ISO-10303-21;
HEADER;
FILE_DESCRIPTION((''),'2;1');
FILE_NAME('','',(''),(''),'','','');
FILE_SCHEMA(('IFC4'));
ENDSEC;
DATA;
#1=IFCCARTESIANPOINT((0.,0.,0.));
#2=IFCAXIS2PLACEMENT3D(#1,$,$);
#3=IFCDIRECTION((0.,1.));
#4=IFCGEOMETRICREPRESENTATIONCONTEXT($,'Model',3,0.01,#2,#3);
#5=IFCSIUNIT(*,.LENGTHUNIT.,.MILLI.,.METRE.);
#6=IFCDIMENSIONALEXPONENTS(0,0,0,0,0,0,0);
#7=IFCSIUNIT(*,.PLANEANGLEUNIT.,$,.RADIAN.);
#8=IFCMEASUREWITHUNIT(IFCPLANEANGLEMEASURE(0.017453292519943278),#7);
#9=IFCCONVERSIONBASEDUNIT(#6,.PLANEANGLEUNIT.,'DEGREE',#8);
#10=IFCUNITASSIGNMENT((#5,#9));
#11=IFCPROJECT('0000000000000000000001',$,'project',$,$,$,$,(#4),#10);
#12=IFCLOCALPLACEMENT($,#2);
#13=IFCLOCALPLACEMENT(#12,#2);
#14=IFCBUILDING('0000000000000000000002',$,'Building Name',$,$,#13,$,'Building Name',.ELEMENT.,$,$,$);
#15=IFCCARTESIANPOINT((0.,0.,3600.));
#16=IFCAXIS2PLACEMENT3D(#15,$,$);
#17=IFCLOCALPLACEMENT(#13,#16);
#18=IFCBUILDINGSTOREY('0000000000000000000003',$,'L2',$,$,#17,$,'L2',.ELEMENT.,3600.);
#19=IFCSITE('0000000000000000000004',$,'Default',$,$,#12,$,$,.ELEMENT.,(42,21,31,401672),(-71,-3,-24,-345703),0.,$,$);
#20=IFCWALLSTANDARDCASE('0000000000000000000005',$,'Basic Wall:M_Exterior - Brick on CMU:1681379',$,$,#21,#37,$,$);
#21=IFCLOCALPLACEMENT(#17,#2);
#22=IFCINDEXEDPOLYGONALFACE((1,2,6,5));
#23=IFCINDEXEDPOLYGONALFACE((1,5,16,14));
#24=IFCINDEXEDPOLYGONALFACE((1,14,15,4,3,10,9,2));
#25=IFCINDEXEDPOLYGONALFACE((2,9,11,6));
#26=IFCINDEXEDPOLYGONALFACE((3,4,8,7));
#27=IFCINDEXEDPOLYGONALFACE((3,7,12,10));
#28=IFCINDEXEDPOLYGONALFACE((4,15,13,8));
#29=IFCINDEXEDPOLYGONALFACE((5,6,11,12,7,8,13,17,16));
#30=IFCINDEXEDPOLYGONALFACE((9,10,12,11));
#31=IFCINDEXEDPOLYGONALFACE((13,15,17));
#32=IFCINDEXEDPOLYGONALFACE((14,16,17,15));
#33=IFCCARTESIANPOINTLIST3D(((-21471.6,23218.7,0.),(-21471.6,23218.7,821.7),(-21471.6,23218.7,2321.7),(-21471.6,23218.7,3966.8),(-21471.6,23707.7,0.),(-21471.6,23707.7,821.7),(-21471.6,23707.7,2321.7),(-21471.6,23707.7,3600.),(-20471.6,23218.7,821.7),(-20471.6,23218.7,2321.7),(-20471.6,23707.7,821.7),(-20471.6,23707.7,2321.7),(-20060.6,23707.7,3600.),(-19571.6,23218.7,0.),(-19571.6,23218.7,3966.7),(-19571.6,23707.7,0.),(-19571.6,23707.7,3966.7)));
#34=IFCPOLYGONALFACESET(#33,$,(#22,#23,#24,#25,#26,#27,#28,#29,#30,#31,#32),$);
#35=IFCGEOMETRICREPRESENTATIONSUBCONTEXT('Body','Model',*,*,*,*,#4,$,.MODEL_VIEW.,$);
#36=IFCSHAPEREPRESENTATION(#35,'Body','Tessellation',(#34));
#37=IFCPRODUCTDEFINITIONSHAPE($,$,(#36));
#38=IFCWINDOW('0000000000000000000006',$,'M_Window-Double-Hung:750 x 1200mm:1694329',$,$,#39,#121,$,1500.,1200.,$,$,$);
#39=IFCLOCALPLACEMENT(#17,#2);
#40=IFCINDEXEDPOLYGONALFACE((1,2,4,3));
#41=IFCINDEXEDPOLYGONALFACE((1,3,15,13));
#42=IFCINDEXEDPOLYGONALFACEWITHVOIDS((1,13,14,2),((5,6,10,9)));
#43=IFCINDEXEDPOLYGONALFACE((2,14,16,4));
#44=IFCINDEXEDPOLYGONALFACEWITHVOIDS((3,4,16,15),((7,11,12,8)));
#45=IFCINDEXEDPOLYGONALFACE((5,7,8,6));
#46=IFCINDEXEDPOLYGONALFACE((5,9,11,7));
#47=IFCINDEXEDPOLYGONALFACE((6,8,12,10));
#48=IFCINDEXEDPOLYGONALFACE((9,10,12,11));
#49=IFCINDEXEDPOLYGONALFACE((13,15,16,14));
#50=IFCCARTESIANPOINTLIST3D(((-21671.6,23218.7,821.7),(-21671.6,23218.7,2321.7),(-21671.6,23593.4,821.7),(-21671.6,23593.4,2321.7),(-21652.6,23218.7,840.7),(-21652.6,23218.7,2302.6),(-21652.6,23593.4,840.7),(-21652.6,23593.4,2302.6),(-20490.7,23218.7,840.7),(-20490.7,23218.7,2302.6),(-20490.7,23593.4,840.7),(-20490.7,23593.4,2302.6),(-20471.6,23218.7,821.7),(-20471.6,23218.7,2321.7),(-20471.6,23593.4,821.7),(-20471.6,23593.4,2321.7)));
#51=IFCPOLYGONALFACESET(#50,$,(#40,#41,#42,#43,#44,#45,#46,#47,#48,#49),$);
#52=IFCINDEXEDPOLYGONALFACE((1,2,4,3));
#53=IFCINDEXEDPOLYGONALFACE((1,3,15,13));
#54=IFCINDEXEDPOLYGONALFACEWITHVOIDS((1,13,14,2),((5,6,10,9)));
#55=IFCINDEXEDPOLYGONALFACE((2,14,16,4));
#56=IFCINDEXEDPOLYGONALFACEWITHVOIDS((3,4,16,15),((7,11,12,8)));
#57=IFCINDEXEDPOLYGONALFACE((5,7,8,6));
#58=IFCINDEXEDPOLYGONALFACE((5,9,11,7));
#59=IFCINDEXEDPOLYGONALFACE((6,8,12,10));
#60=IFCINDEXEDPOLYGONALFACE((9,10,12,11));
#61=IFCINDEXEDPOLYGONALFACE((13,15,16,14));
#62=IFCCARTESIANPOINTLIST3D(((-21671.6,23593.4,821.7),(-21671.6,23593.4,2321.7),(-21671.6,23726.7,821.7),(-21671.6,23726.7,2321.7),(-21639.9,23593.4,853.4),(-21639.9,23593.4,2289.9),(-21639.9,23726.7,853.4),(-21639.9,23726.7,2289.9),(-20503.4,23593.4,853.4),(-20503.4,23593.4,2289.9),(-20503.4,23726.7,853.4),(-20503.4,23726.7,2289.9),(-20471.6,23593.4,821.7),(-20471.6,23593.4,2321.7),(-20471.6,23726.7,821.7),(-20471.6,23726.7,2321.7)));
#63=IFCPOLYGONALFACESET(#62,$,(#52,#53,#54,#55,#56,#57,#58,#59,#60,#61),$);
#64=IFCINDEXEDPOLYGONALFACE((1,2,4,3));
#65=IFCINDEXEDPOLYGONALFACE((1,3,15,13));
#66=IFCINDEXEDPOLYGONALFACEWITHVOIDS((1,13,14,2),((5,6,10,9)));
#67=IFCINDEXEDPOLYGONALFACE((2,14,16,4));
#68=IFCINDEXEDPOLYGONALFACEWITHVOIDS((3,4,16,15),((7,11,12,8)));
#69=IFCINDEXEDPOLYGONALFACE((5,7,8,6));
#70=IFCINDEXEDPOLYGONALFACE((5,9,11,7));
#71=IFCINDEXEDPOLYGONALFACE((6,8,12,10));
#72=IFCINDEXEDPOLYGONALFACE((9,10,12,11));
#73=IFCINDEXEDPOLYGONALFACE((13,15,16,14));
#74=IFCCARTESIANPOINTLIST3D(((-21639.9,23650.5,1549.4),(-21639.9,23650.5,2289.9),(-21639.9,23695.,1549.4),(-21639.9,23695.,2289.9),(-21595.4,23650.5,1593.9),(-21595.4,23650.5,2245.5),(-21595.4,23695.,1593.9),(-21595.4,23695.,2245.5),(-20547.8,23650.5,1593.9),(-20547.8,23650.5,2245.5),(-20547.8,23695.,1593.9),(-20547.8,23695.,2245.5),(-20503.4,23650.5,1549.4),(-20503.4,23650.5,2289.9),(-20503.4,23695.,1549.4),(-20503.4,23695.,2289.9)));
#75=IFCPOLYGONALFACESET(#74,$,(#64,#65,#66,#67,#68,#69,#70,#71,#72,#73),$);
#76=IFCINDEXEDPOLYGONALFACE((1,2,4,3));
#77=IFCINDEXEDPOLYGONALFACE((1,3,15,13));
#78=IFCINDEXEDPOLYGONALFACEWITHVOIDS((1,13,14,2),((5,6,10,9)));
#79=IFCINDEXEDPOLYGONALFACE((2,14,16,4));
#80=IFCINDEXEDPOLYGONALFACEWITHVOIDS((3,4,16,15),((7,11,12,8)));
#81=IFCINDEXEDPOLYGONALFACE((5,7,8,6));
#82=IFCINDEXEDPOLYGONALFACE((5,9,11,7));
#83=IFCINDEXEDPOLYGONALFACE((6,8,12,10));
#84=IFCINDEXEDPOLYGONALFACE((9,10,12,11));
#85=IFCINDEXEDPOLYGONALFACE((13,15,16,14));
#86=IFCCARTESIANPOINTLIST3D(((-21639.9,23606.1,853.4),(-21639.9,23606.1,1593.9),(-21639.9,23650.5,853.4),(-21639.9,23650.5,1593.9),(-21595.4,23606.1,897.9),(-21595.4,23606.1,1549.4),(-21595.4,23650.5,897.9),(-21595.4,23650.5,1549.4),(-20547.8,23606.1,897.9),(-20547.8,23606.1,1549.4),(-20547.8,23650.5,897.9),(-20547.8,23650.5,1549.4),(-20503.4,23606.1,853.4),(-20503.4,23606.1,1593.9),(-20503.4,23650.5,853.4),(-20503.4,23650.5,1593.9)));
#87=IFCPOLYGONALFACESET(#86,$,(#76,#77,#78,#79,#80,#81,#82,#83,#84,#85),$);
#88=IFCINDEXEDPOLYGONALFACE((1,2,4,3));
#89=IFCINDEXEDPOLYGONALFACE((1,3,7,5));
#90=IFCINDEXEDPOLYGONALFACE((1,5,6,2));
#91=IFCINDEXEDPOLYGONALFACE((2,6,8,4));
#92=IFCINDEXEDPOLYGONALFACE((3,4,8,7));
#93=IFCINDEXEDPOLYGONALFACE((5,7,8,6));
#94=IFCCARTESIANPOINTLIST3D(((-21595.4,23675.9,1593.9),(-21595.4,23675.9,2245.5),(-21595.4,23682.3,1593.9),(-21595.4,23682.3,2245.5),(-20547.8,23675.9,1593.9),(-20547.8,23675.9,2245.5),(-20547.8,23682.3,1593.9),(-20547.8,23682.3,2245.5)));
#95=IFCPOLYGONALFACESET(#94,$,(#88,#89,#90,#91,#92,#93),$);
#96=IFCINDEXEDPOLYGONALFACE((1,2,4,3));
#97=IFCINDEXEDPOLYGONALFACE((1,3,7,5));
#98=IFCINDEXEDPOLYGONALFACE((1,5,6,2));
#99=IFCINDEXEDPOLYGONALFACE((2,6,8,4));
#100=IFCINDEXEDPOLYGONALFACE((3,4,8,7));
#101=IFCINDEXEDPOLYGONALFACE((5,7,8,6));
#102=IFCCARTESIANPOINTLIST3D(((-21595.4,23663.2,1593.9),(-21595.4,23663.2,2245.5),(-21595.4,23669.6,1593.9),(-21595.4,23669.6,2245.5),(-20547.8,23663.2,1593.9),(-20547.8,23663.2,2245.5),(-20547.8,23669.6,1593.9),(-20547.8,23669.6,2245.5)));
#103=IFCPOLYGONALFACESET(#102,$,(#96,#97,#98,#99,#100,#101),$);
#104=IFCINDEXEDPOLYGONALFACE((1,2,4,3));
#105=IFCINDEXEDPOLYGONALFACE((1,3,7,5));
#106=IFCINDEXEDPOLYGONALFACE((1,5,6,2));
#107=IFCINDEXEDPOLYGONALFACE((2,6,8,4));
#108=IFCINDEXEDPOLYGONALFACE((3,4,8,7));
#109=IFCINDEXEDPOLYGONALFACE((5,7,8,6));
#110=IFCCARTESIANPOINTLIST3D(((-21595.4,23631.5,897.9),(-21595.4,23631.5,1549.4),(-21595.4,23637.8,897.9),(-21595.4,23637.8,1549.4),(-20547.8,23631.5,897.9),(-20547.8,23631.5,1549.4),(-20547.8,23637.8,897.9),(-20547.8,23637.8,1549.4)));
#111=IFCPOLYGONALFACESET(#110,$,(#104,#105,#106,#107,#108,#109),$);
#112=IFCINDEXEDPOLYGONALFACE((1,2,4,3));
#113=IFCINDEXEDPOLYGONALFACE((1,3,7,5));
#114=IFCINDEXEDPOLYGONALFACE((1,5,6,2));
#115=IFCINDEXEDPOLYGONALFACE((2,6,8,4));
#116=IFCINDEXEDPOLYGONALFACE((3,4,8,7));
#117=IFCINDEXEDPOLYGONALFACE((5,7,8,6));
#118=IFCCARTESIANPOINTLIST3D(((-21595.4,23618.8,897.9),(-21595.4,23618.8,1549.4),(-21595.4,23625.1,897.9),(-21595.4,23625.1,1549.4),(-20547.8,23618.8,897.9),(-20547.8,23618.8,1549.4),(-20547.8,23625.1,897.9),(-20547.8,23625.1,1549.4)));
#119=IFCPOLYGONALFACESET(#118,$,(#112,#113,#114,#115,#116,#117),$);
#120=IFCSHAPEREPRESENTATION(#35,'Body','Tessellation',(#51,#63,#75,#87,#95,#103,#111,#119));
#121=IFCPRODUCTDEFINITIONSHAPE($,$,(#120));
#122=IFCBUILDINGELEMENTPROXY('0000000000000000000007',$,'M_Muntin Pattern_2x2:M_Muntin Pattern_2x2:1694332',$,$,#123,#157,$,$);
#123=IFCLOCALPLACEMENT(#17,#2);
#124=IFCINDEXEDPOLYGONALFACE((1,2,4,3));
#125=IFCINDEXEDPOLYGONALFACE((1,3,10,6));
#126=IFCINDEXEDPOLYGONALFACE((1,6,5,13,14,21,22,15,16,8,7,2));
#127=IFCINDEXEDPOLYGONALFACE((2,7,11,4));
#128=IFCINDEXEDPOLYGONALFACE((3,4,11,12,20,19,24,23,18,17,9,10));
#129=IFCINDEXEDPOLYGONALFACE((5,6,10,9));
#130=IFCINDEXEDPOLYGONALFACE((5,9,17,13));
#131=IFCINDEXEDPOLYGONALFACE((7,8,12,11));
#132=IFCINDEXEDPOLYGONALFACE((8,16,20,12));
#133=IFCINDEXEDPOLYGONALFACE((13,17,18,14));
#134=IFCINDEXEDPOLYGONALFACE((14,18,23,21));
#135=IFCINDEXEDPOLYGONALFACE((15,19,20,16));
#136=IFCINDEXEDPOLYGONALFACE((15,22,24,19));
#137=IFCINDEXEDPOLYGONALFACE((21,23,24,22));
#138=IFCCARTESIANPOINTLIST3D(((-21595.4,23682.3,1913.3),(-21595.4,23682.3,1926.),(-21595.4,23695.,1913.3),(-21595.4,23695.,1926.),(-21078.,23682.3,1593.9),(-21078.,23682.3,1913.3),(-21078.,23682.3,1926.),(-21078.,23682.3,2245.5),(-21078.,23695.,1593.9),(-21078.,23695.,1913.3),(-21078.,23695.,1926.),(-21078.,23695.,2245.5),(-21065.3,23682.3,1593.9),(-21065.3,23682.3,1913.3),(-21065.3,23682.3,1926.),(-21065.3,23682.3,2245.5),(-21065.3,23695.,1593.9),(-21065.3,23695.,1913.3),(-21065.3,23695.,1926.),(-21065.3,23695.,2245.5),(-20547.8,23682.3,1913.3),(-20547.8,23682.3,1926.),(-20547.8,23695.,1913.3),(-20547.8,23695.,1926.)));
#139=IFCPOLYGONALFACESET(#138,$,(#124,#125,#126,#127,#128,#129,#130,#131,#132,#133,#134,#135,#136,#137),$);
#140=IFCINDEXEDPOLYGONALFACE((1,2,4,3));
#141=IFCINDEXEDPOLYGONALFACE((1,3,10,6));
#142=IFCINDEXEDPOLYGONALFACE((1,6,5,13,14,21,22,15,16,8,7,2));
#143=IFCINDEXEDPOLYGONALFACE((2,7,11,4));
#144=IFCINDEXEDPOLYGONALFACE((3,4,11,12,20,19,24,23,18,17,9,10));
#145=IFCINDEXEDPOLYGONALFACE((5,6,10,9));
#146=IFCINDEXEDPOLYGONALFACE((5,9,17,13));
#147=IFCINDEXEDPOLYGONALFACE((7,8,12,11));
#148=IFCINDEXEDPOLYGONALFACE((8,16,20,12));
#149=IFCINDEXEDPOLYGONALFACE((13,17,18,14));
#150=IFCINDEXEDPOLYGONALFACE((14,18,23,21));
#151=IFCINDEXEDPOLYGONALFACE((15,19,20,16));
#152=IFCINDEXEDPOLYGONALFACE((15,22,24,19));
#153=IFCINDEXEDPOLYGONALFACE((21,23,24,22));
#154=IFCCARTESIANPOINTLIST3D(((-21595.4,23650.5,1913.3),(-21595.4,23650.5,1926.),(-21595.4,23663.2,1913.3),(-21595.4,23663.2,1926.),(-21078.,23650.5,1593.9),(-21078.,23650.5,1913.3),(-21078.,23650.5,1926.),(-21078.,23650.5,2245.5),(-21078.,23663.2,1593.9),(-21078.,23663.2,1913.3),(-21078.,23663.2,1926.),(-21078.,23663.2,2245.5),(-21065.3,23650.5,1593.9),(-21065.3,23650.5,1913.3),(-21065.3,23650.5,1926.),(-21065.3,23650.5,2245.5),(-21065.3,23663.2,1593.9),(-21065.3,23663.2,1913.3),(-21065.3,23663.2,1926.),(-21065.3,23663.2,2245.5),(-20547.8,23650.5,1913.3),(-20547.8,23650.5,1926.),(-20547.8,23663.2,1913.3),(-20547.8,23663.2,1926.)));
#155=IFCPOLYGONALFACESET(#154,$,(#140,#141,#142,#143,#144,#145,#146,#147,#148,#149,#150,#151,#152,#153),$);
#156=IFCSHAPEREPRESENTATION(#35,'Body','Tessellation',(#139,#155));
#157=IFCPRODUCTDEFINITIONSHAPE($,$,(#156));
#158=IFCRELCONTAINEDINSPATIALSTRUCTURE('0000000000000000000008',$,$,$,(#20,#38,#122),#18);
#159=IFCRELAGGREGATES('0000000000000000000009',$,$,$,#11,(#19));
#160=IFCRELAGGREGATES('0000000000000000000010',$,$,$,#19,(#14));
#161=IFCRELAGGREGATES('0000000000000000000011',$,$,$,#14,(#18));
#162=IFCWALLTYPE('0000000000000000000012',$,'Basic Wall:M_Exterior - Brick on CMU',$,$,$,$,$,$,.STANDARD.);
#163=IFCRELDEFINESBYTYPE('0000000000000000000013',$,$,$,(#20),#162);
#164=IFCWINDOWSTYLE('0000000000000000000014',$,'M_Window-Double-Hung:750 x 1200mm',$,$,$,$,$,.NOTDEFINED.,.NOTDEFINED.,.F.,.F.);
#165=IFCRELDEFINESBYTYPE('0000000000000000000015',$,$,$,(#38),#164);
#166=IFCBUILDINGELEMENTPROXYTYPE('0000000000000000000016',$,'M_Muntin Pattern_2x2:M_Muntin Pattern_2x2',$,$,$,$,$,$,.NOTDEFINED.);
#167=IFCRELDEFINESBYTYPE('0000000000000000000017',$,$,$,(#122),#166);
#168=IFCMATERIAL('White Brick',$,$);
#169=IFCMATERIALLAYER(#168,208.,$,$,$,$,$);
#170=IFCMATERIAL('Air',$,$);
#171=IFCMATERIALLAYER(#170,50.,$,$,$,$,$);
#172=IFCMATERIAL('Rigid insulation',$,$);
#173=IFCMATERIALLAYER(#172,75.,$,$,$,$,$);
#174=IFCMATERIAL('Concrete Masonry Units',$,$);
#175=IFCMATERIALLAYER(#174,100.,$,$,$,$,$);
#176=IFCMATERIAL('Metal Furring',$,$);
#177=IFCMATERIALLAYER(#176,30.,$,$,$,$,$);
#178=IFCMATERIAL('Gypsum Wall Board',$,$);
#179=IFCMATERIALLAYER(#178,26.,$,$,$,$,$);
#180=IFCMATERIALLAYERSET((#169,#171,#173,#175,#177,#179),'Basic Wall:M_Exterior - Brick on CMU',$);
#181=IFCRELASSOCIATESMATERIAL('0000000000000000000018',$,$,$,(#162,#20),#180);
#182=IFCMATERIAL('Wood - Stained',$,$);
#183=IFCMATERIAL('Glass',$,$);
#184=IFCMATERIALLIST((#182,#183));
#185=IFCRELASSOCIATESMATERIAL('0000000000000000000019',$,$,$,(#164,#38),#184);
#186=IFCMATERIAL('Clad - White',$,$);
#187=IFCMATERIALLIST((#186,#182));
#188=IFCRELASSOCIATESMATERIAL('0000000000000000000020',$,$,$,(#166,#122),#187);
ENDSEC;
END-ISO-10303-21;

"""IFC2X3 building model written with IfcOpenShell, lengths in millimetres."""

from ifc_helpers import new_model, entity, si_unit, converted_unit, direction, frame, frame_2d, origin, place, context, subcontext, project, spatial, polyline, rectangle, outline, extrude, clip, bounded_halfspace, source, transform, mapped, material, material_list, layer, layer_set, layer_usage, type_object, type_shapes, element, fill, save


model = new_model("IFC2X3")

# Units and contexts
model_context = context("Model", 3, precision=0.01, world=origin(), true_north=direction((0.0, 1.0)))
body_context = subcontext(model_context, "Body", "Model", "MODEL_VIEW")
ifc_project = project(units=[si_unit("LENGTHUNIT", "METRE", prefix="MILLI"), converted_unit("PLANEANGLEUNIT", "DEGREE", entity("IfcPlaneAngleMeasure", 0.017453292519943278), si_unit("PLANEANGLEUNIT", "RADIAN"), dimensions=[0, 0, 0, 0, 0, 0, 0])], contexts=[model_context])

# Site, building, storey
site_placement = place(None, origin())
site = spatial("IfcSite", under=ifc_project, at=site_placement, Name="Default", CompositionType="ELEMENT", RefLatitude=(42, 21, 31, 401672), RefLongitude=(-71, -3, -24, -345703), RefElevation=0.0)
building_placement = place(site_placement, origin())
building = spatial("IfcBuilding", under=site, at=building_placement, Name="Building Name", LongName="Building Name", CompositionType="ELEMENT")
storey_placement = place(building_placement, frame((0.0, 0.0, 3600.0)))
storey = spatial("IfcBuildingStorey", under=building, at=storey_placement, Name="L2", LongName="L2", CompositionType="ELEMENT", Elevation=3600.0)

# Shared definitions
ifc_material_1 = material(Name="White Brick")
ifc_layer_1 = layer(ifc_material_1, 208.0)
ifc_material_2 = material(Name="Air")
ifc_layer_2 = layer(ifc_material_2, 50.0)
ifc_material_3 = material(Name="Rigid insulation")
ifc_layer_3 = layer(ifc_material_3, 75.0)
ifc_material_4 = material(Name="Concrete Masonry Units")
ifc_layer_4 = layer(ifc_material_4, 100.0)
ifc_material_5 = material(Name="Metal Furring")
ifc_layer_5 = layer(ifc_material_5, 30.0)
ifc_material_6 = material(Name="Gypsum Wall Board")
ifc_layer_6 = layer(ifc_material_6, 26.0)
ifc_layer_set_1 = layer_set([ifc_layer_1, ifc_layer_2, ifc_layer_3, ifc_layer_4, ifc_layer_5, ifc_layer_6], Name="Basic Wall:M_Exterior - Brick on CMU")
wall_type = type_object("IfcWallType", Name="Basic Wall:M_Exterior - Brick on CMU", PredefinedType="STANDARD", material=ifc_layer_set_1)
ifc_material_7 = material(Name="Wood - Stained")
ifc_material_8 = material(Name="Glass")
ifc_material_list_1 = material_list([ifc_material_7, ifc_material_8])
window_style = type_object("IfcWindowStyle", Name="M_Window-Double-Hung:750 x 1200mm", ConstructionType="NOTDEFINED", OperationType="NOTDEFINED", ParameterTakesPrecedence=False, Sizeable=False, material=ifc_material_list_1)
shared_shape_1 = source(origin(), body_context, "Body", "SweptSolid", [
    extrude(outline(polyline([(-750.0, -600.0), (750.0, -600.0), (750.0, 600.0), (-750.0, 600.0), (-750.0, -600.0)]), holes=[polyline([(-730.9, -580.9), (-730.9, 580.9), (730.9, 580.9), (730.9, -580.9), (-730.9, -580.9)])]), frame((600.0, 0.0, 750.0), z_axis=(0.0, 1.0, 0.0), x_axis=(0.0, 0.0, -1.0)), (0.0, 0.0, 1.0), 374.7),
    extrude(outline(polyline([(-600.0, -750.0), (600.0, -750.0), (600.0, 750.0), (-600.0, 750.0), (-600.0, -750.0)]), holes=[polyline([(568.2, -718.2), (-568.2, -718.2), (-568.2, 718.2), (568.2, 718.2), (568.2, -718.2)])]), frame((600.0, 374.7, 750.0), z_axis=(0.0, 1.0, 0.0), x_axis=(1.0, 0.0, 0.0)), (0.0, 0.0, 1.0), 133.3),
    extrude(outline(polyline([(-568.2, -370.2), (568.2, -370.2), (568.2, 370.2), (-568.2, 370.2), (-568.2, -370.2)]), holes=[polyline([(523.8, -325.8), (-523.8, -325.8), (-523.8, 325.8), (523.8, 325.8), (523.8, -325.8)])]), frame((600.0, 431.8, 1098.0), z_axis=(0.0, 1.0, 0.0), x_axis=(1.0, 0.0, 0.0)), (0.0, 0.0, 1.0), 44.4),
    extrude(outline(polyline([(-568.2, -370.2), (568.2, -370.2), (568.2, 370.2), (-568.2, 370.2), (-568.2, -370.2)]), holes=[polyline([(523.8, -325.8), (-523.8, -325.8), (-523.8, 325.8), (523.8, 325.8), (523.8, -325.8)])]), frame((600.0, 387.4, 402.0), z_axis=(0.0, 1.0, 0.0), x_axis=(1.0, 0.0, 0.0)), (0.0, 0.0, 1.0), 44.5),
    extrude(rectangle(XDim=1047.6, YDim=6.4, at=frame_2d((0.0, 0.0), x_axis=(1.0, 0.0))), frame((600.0, 460.4, 772.2), z_axis=(0.0, 0.0, 1.0), x_axis=(-1.0, 0.0, 0.0)), (0.0, 0.0, 1.0), 651.6),
    extrude(rectangle(XDim=6.4, YDim=1047.6, at=frame_2d((0.0, 0.0), x_axis=(1.0, 0.0))), frame((600.0, 447.7, 772.2), z_axis=(0.0, 0.0, 1.0), x_axis=(0.0, -1.0, 0.0)), (0.0, 0.0, 1.0), 651.6),
    extrude(rectangle(XDim=1047.6, YDim=6.4, at=frame_2d((0.0, 0.0), x_axis=(1.0, 0.0))), frame((600.0, 416.0, 76.2), z_axis=(0.0, 0.0, 1.0), x_axis=(-1.0, 0.0, 0.0)), (0.0, 0.0, 1.0), 651.6),
    extrude(rectangle(XDim=6.4, YDim=1047.6, at=frame_2d((0.0, 0.0), x_axis=(1.0, 0.0))), frame((600.0, 403.3, 76.2), z_axis=(0.0, 0.0, 1.0), x_axis=(0.0, -1.0, 0.0)), (0.0, 0.0, 1.0), 651.6),
])
type_shapes(window_style, [shared_shape_1])

# Wall, opening, window
ifc_layer_usage_1 = layer_usage(ifc_layer_set_1, "AXIS2", "NEGATIVE", 244.5)
wall_1_placement = place(storey_placement, frame((-21471.6, 23463.2, 0.0)))
wall_1 = element("IfcWallStandardCase", 1, at=wall_1_placement, inside=storey, type_object=wall_type, material=ifc_layer_usage_1, Name="Basic Wall:M_Exterior - Brick on CMU:1681379", context=body_context, shape_type="Clipping", body=[
    clip(clip(extrude(rectangle(XDim=1900.0, YDim=489.0, at=frame_2d((950.0, 0.0), x_axis=(-1.0, 0.0))), origin(), (0.0, 0.0, 1.0), 3966.7), bounded_halfspace(frame((0.0, 244.5, 3600.0), z_axis=(0.0, 0.6, 0.8), x_axis=(-1.0, 0.0, 0.0)), False, frame((0.0, 244.5, 3600.0)), polyline([(0.0, 0.0), (0.0, -489.0), (1900.0, -489.0), (1411.0, 0.0), (0.0, 0.0)]))), bounded_halfspace(frame((1900.0, -244.5, 3966.7), z_axis=(-0.6, 0.0, 0.8), x_axis=(0.0, -1.0, 0.0)), False, frame((1900.0, -244.5, 3966.7)), polyline([(0.0, 0.0), (0.0, 280.0), (0.0, 405.0), (0.0, 489.0), (-489.0, 489.0), (0.0, 0.0)]))),
])
opening_1_placement = place(wall_1_placement, frame((-200.0, -244.5, 821.7)))
opening_1 = element("IfcOpeningElement", 2, at=opening_1_placement, cuts=wall_1, ObjectType="Opening", context=body_context, shape_type="SweptSolid", body=[
    extrude(rectangle(XDim=1500.0, YDim=1200.0, at=frame_2d((750.0, 600.0), x_axis=(-1.0, 0.0))), frame((0.0, 0.0, 0.0), z_axis=(0.0, 1.0, 0.0), x_axis=(0.0, 0.0, 1.0)), (0.0, 0.0, 1.0), 489.0),
])
window_1_placement = place(opening_1_placement, origin())
window_1 = element("IfcWindow", 3, at=window_1_placement, inside=storey, type_object=window_style, material=ifc_material_list_1, Name="M_Window-Double-Hung:750 x 1200mm:1694329", OverallHeight=1500.0, OverallWidth=1200.0, context=body_context, shape_type="MappedRepresentation", body=[
    mapped(shared_shape_1, transform((0.0, 0.0, 0.0), scale=1.0)),
])
fill(opening_1, window_1)

# Building element proxy
ifc_material_9 = material(Name="Clad - White")
ifc_material_list_2 = material_list([ifc_material_9, ifc_material_7])
building_element_proxy_type_1 = type_object("IfcBuildingElementProxyType", Name="M_Muntin Pattern_2x2:M_Muntin Pattern_2x2", PredefinedType="NOTDEFINED", material=ifc_material_list_2)
shared_shape_2 = source(origin(), body_context, "Body", "SweptSolid", [
    extrude(outline(polyline([(6.4, -6.4), (325.8, -6.4), (325.8, 6.3), (6.4, 6.3), (6.4, 523.8), (-6.3, 523.8), (-6.3, 6.3), (-325.8, 6.3), (-325.8, -6.4), (-6.3, -6.4), (-6.3, -523.8), (6.4, -523.8), (6.4, -6.4)])), frame((0.0, 9.5, 325.8), z_axis=(0.0, 1.0, 0.0), x_axis=(0.0, 0.0, 1.0)), (0.0, 0.0, 1.0), 12.7),
    extrude(outline(polyline([(6.4, -6.4), (325.8, -6.4), (325.8, 6.3), (6.4, 6.3), (6.4, 523.8), (-6.3, 523.8), (-6.3, 6.3), (-325.8, 6.3), (-325.8, -6.4), (-6.3, -6.4), (-6.3, -523.8), (6.4, -523.8), (6.4, -6.4)])), frame((0.0, -22.2, 325.8), z_axis=(0.0, 1.0, 0.0), x_axis=(0.0, 0.0, 1.0)), (0.0, 0.0, 1.0), 12.7),
])
type_shapes(building_element_proxy_type_1, [shared_shape_2])
for number, where, name in (
    (4, (-21071.6, 23672.7, 1593.9), "M_Muntin Pattern_2x2:M_Muntin Pattern_2x2:1694332"),
):
    element("IfcBuildingElementProxy", number, at=place(storey_placement, frame(where)), inside=storey, type_object=building_element_proxy_type_1, material=ifc_material_list_2, Name=name, context=body_context, shape_type="MappedRepresentation", body=[
        mapped(shared_shape_2, transform((0.0, 0.0, 0.0), scale=1.0)),
    ])

save(model, "model.ifc")
